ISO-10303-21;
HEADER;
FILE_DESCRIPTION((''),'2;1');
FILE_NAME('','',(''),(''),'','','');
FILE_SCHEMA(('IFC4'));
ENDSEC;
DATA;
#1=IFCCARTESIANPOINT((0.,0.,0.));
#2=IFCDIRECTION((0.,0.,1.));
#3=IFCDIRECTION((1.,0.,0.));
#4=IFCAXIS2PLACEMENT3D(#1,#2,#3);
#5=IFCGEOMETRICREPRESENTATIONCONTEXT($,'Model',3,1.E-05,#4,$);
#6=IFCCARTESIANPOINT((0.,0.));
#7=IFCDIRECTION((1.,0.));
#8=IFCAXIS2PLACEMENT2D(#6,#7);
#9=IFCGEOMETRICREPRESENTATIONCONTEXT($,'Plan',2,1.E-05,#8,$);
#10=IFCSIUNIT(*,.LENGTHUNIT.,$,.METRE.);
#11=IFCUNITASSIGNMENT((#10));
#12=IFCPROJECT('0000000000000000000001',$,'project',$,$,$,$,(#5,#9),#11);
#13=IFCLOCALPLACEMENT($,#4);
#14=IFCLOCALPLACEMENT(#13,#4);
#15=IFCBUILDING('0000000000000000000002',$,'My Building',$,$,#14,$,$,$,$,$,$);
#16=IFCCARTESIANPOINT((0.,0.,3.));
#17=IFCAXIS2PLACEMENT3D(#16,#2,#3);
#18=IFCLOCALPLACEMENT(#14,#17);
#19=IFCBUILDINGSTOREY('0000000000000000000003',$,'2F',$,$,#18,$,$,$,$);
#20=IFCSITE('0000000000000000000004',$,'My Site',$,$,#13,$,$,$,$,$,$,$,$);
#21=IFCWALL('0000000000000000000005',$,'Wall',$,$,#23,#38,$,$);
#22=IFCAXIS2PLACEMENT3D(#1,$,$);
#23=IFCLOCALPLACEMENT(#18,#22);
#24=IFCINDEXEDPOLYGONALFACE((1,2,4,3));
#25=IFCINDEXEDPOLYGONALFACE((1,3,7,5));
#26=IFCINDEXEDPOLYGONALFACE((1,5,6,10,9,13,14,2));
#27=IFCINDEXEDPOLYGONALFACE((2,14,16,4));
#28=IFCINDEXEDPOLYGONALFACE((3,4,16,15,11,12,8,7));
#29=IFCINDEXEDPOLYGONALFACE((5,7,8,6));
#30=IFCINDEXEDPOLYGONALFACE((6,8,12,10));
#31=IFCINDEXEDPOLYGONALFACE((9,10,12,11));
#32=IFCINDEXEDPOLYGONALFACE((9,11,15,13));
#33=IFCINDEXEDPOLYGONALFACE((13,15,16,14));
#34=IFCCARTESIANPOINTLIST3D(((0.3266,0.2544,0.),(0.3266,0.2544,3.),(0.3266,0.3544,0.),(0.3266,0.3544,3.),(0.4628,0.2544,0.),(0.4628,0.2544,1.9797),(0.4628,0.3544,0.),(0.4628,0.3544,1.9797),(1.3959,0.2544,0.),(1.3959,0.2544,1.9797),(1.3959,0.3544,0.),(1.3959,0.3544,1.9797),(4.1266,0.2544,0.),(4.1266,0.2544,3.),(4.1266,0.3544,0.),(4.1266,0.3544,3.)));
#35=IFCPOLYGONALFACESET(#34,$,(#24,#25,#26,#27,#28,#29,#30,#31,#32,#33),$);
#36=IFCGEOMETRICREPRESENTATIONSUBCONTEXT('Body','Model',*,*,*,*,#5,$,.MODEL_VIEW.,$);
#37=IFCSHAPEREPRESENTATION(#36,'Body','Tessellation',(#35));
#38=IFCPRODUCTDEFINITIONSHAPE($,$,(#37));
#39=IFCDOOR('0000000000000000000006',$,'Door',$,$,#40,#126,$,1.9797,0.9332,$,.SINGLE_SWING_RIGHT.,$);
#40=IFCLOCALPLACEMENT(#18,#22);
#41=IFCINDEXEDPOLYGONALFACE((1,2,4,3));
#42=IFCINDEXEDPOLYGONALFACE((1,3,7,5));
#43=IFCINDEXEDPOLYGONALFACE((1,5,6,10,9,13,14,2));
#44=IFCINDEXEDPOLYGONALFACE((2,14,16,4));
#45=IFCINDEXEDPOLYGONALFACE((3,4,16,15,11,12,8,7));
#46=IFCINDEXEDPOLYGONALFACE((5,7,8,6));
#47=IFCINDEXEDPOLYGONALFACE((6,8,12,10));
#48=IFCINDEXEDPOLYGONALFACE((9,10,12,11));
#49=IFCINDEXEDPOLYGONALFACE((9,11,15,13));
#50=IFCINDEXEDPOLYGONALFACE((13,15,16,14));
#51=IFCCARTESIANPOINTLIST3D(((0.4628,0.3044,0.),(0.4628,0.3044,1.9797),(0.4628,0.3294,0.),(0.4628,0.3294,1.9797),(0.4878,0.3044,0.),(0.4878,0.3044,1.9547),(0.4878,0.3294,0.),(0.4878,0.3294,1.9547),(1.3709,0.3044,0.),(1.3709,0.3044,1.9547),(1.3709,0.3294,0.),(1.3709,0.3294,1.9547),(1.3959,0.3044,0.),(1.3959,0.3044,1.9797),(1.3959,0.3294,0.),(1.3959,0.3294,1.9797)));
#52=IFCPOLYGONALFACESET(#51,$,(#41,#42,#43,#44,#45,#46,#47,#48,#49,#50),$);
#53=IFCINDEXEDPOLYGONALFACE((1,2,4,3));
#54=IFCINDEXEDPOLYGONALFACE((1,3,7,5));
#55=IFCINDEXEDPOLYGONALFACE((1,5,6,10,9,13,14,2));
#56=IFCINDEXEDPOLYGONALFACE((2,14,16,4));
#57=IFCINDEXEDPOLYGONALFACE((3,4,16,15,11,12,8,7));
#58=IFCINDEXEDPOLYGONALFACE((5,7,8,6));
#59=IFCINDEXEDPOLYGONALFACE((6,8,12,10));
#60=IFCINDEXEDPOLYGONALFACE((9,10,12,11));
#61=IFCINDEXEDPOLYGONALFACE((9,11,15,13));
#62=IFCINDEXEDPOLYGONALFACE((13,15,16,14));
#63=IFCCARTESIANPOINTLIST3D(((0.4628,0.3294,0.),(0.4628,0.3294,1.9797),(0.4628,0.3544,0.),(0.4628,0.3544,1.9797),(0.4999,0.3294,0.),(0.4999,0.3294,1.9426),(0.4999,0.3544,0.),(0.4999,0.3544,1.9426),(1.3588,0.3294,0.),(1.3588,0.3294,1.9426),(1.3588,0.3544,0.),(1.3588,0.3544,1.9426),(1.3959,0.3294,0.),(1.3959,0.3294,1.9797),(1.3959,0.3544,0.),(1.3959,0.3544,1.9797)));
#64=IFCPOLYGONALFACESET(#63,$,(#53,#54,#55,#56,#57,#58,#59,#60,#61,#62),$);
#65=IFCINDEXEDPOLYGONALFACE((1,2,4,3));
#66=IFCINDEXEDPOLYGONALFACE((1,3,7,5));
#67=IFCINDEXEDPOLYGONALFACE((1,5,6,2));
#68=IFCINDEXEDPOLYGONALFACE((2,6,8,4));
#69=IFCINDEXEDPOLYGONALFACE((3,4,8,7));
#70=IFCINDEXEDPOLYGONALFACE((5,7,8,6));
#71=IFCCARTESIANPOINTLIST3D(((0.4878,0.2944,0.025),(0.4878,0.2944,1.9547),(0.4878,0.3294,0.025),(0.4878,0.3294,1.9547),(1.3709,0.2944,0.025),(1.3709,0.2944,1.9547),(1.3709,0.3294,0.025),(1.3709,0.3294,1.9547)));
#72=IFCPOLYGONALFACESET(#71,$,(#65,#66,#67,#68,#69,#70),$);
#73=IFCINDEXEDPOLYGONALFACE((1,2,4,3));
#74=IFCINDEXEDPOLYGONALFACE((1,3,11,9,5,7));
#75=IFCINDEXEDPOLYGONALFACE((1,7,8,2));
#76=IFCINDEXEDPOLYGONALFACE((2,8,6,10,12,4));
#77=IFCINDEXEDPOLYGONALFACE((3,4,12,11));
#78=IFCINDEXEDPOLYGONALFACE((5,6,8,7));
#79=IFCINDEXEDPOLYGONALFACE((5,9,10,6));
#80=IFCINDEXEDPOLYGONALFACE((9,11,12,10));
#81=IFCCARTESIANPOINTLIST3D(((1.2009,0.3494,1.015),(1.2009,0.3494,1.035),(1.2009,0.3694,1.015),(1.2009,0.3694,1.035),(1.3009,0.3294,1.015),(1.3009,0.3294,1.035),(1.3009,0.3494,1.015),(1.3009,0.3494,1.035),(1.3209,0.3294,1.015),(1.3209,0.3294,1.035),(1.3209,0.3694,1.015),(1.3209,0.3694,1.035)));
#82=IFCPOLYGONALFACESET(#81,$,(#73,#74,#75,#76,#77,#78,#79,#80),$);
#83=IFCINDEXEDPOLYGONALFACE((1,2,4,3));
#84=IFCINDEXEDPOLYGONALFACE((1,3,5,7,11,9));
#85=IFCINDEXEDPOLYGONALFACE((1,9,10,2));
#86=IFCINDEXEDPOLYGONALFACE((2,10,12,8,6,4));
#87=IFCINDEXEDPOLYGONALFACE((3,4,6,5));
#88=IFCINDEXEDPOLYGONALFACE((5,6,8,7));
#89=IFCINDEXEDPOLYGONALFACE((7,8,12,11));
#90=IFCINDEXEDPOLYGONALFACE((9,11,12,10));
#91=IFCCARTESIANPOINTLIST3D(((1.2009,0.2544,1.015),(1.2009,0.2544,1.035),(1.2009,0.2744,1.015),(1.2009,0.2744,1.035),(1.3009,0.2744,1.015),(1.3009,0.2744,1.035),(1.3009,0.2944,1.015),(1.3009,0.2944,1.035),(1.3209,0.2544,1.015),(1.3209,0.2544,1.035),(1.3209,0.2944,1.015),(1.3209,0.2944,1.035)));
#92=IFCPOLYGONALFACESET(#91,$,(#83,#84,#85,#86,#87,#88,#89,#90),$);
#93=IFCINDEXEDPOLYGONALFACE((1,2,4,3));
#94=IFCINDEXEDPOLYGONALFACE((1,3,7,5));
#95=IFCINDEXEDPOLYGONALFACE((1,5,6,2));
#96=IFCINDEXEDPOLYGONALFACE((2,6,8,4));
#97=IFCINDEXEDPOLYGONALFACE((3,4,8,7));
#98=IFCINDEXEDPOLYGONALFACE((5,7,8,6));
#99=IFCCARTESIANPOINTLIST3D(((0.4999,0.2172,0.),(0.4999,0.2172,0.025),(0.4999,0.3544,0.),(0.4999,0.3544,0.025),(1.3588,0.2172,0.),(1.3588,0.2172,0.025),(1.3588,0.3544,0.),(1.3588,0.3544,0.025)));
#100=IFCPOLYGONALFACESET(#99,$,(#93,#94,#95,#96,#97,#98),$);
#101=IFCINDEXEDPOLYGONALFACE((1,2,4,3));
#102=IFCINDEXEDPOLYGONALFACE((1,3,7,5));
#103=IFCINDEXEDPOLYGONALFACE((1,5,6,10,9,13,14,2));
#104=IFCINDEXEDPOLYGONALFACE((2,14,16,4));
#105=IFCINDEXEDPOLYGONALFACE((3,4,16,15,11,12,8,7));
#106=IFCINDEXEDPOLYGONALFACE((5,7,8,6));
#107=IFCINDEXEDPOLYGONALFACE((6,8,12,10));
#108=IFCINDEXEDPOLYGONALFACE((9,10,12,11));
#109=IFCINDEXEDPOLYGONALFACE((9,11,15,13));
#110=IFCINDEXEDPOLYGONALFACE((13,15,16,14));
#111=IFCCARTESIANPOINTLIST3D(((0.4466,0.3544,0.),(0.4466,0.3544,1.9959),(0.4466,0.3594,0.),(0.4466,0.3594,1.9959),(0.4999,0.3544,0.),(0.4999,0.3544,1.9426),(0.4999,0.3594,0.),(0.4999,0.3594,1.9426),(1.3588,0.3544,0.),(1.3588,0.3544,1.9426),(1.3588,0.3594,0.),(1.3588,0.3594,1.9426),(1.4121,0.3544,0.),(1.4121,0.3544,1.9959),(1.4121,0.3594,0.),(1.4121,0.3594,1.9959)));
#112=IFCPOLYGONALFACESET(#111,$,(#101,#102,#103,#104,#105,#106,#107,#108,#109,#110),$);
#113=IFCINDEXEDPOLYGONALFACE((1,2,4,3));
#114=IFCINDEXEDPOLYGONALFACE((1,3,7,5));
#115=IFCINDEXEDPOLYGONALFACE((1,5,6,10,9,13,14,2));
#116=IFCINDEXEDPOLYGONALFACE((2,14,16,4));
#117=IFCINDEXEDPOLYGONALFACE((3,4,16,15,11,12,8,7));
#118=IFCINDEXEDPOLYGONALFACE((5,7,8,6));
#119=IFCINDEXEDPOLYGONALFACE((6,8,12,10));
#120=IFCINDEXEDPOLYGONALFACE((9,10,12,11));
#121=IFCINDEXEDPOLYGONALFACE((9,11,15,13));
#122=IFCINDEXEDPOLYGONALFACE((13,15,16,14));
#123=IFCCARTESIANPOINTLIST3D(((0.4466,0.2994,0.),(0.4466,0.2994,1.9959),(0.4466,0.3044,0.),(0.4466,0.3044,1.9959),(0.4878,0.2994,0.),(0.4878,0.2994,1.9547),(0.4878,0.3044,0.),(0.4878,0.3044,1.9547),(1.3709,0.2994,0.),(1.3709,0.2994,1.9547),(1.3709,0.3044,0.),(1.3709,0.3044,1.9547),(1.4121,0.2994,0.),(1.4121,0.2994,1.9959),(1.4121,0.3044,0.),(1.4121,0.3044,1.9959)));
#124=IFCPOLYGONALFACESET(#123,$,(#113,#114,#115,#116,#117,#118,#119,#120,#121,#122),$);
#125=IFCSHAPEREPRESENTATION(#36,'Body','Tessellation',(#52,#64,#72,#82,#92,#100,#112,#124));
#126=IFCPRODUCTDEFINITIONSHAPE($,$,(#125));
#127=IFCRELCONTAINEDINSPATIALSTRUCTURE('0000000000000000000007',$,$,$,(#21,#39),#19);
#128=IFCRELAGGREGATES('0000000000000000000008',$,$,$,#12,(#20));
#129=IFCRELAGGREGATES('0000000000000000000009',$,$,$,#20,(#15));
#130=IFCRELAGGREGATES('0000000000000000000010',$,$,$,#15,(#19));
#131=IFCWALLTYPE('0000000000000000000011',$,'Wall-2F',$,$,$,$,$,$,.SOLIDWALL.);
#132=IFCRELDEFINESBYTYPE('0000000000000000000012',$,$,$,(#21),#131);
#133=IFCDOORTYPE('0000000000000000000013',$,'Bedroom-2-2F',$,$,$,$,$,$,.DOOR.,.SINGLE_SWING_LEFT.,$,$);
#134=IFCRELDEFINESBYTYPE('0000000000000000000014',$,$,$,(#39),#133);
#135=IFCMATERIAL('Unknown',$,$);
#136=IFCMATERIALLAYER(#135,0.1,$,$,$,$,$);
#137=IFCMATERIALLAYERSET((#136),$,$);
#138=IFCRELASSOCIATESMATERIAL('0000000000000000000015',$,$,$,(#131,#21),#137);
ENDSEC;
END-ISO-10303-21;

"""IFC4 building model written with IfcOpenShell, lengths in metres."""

from ifc_helpers import new_model, entity, si_unit, frame, origin_with_axes, origin_2d_with_axis, place, context, subcontext, project, spatial, line, indexed_curve, outline, extrude, shape, source, transform, mapped, material, layer, layer_set, layer_usage, type_object, type_shapes, element, fill, save


model = new_model("IFC4")

# Units and contexts
model_context = context("Model", 3, precision=1e-05, world=origin_with_axes())
plan_context = context("Plan", 2, precision=1e-05, world=origin_2d_with_axis())
body_context_1 = subcontext(model_context, "Body", "Model", "MODEL_VIEW")
body_context_2 = subcontext(plan_context, "Body", "Plan", "PLAN_VIEW")
ifc_project = project(units=[si_unit("LENGTHUNIT", "METRE")], contexts=[model_context, plan_context])

# Site, building, storey
site_placement = place(None, origin_with_axes())
site = spatial("IfcSite", under=ifc_project, at=site_placement, Name="My Site")
building_placement = place(site_placement, origin_with_axes())
building = spatial("IfcBuilding", under=site, at=building_placement, Name="My Building")
storey_placement = place(building_placement, frame((0.0, 0.0, 3.0), z_axis=(0.0, 0.0, 1.0), x_axis=(1.0, 0.0, 0.0)))
storey = spatial("IfcBuildingStorey", under=building, at=storey_placement, Name="2F")

# Shared definitions
ifc_material = material(Name="Unknown")

# Shared definitions
ifc_layer_1 = layer(ifc_material, 0.1)
ifc_layer_set_1 = layer_set([ifc_layer_1])
wall_type = type_object("IfcWallType", Name="Wall-2F", PredefinedType="SOLIDWALL", material=ifc_layer_set_1)

# Wall, opening, door
ifc_layer_usage_1 = layer_usage(ifc_layer_set_1, "AXIS2", "POSITIVE", 0.0)
wall_1_placement = place(storey_placement, frame((0.3266, 0.2544, 0.0), z_axis=(0.0, 0.0, 1.0), x_axis=(1.0, 0.0, 0.0)))
wall_1 = element("IfcWall", 1, at=wall_1_placement, inside=storey, type_object=wall_type, material=ifc_layer_usage_1, Name="Wall", context=body_context_1, shape_type="SweptSolid", body=[
    extrude(outline(indexed_curve([(0.0, 0.0), (0.0, 0.1), (3.8, 0.1), (3.8, 0.0)], segments=[line(1, 2, 3, 4, 1)])), origin_with_axes(), (0.0, 0.0, 1.0), 3.0),
])
shared_shape_1 = source(origin_with_axes(), body_context_1, "Body", "SweptSolid", [
    extrude(outline(indexed_curve([(0.0, 0.0), (0.9332, 0.0), (0.9332, 1.9797), (0.0, 1.9797)], segments=[line(1, 2, 3, 4, 1)])), frame((0.0, -0.6, 0.0), z_axis=(0.0, -1.0, 0.0), x_axis=(1.0, 0.0, 0.0)), (0.0, 0.0, -1.0), 1.2),
])
opening_1_placement = place(wall_1_placement, frame((1.0693, 0.1, 0.0), z_axis=(0.0, 0.0, 1.0), x_axis=(-1.0, 0.0, 0.0)))
opening_1 = element("IfcOpeningElement", 2, at=opening_1_placement, cuts=wall_1, PredefinedType="OPENING", context=body_context_1, shape_type="MappedRepresentation", body=[
    mapped(shared_shape_1, transform((0.0, 0.0, 0.0), x_axis=(1.0, 0.0, 0.0), y_axis=(0.0, 1.0, 0.0), z_axis=(0.0, 0.0, 1.0), scale=1.0)),
])
door_type_1 = type_object("IfcDoorType", Name="Bedroom-2-2F", OperationType="SINGLE_SWING_LEFT", PredefinedType="DOOR")
shared_shape_2 = source(origin_with_axes(), body_context_1, "Body", "SweptSolid", [
    extrude(outline(indexed_curve([(0.0, 0.0), (0.0, 1.9797), (0.9332, 1.9797), (0.9332, 0.0), (0.9082, 0.0), (0.9082, 1.9547), (0.025, 1.9547), (0.025, 0.0)], segments=[line(1, 2, 3, 4, 5, 6, 7, 8, 1)])), frame((0.0, 0.025, 0.0), z_axis=(0.0, -1.0, 0.0), x_axis=(1.0, 0.0, 0.0)), (0.0, 0.0, -1.0), 0.025),
    extrude(outline(indexed_curve([(0.0, 0.0), (0.0, 1.9797), (0.9332, 1.9797), (0.9332, 0.0), (0.8961, 0.0), (0.8961, 1.9426), (0.0371, 1.9426), (0.0371, 0.0)], segments=[line(1, 2, 3, 4, 5, 6, 7, 8, 1)])), frame((0.0, 0.0, 0.0), z_axis=(0.0, -1.0, 0.0), x_axis=(1.0, 0.0, 0.0)), (0.0, 0.0, -1.0), 0.025),
    extrude(outline(indexed_curve([(0.0, 0.0), (0.8832, 0.0), (0.8832, 0.035), (0.0, 0.035)], segments=[line(1, 2, 3, 4, 1)])), frame((0.025, 0.025, 0.025), z_axis=(0.0, 0.0, 1.0), x_axis=(1.0, 0.0, 0.0)), (0.0, 0.0, 1.0), 1.9297),
    extrude(outline(indexed_curve([(0.0, 0.0), (0.0, -0.04), (0.12, -0.04), (0.12, -0.02), (0.02, -0.02), (0.02, 0.0)], segments=[line(1, 2, 3, 4, 5, 6, 1)])), frame((0.075, 0.025, 1.015), z_axis=(0.0, 0.0, 1.0), x_axis=(1.0, 0.0, 0.0)), (0.0, 0.0, 1.0), 0.02),
    extrude(outline(indexed_curve([(0.0, 0.0), (0.0, 0.04), (0.12, 0.04), (0.12, 0.02), (0.02, 0.02), (0.02, 0.0)], segments=[line(1, 2, 3, 4, 5, 6, 1)])), frame((0.075, 0.06, 1.015), z_axis=(0.0, 0.0, 1.0), x_axis=(1.0, 0.0, 0.0)), (0.0, 0.0, 1.0), 0.02),
    extrude(outline(indexed_curve([(0.0, 0.0), (0.859, 0.0), (0.859, 0.1372), (0.0, 0.1372)], segments=[line(1, 2, 3, 4, 1)])), frame((0.0371, 0.0, 0.0), z_axis=(0.0, 0.0, 1.0), x_axis=(1.0, 0.0, 0.0)), (0.0, 0.0, 1.0), 0.025),
    extrude(outline(indexed_curve([(0.0, 0.0), (0.0, 1.9959), (0.9655, 1.9959), (0.9655, 0.0), (0.9122, 0.0), (0.9122, 1.9426), (0.0532, 1.9426), (0.0532, 0.0)], segments=[line(1, 2, 3, 4, 5, 6, 7, 8, 1)])), frame((-0.0162, -0.005, 0.0), z_axis=(0.0, -1.0, 0.0), x_axis=(1.0, 0.0, 0.0)), (0.0, 0.0, -1.0), 0.005),
    extrude(outline(indexed_curve([(0.0, 0.0), (0.0, 1.9959), (0.9655, 1.9959), (0.9655, 0.0), (0.9243, 0.0), (0.9243, 1.9547), (0.0412, 1.9547), (0.0412, 0.0)], segments=[line(1, 2, 3, 4, 5, 6, 7, 8, 1)])), frame((-0.0162, 0.05, 0.0), z_axis=(0.0, -1.0, 0.0), x_axis=(1.0, 0.0, 0.0)), (0.0, 0.0, -1.0), 0.005),
])
shared_shape_3 = source(origin_with_axes(), body_context_2, "Body", "Curve2D", [
    entity("IfcIndexedPolyCurve", entity("IfcCartesianPointList2D", [[0.0, 0.0], [0.0, 0.05], [0.025, 0.05], [0.025, 0.025], [0.0371, 0.025], [0.0371, 0.0]]), [entity("IfcLineIndex", [1, 2, 3, 4, 5, 6, 1])]),
    entity("IfcIndexedPolyCurve", entity("IfcCartesianPointList2D", [[0.9332, 0.0], [0.9332, 0.05], [0.9082, 0.05], [0.9082, 0.025], [0.8961, 0.025], [0.8961, 0.0]]), [entity("IfcLineIndex", [1, 2, 3, 4, 5, 6, 1])]),
    entity("IfcTrimmedCurve", entity("IfcEllipse", entity("IfcAxis2Placement2D", entity("IfcCartesianPoint", [0.8732, 0.05]), entity("IfcDirection", [1.0, 0.0])), 0.8482, 0.8832), [entity("IfcCartesianPoint", [0.8732, 0.9332])], [entity("IfcCartesianPoint", [0.025, 0.05])], True, "CARTESIAN"),
    entity("IfcIndexedPolyCurve", entity("IfcCartesianPointList2D", [[0.9082, 0.05], [0.8732, 0.05], [0.8732, 0.9332], [0.9082, 0.9332]]), [entity("IfcLineIndex", [1, 2, 3, 4, 1])]),
])
type_shapes(door_type_1, [shared_shape_2, shared_shape_3])
door_1_placement = place(opening_1_placement, origin_with_axes())
door_1 = element("IfcDoor", 3, at=door_1_placement, inside=storey, type_object=door_type_1, Name="Door", OperationType="SINGLE_SWING_RIGHT", OverallHeight=1.9797, OverallWidth=0.9332, shapes=[
    shape(body_context_1, "Body", "MappedRepresentation", [mapped(shared_shape_2, transform((0.0, 0.0, 0.0), x_axis=(1.0, 0.0, 0.0), y_axis=(0.0, 1.0, 0.0), z_axis=(0.0, 0.0, 1.0), scale=1.0))]),
    shape(body_context_2, "Body", "MappedRepresentation", [mapped(shared_shape_3, transform((0.0, 0.0, 0.0), x_axis=(1.0, 0.0, 0.0), y_axis=(0.0, 1.0, 0.0), z_axis=(0.0, 0.0, 1.0), scale=1.0))]),
])
fill(opening_1, door_1)

save(model, "model.ifc")
